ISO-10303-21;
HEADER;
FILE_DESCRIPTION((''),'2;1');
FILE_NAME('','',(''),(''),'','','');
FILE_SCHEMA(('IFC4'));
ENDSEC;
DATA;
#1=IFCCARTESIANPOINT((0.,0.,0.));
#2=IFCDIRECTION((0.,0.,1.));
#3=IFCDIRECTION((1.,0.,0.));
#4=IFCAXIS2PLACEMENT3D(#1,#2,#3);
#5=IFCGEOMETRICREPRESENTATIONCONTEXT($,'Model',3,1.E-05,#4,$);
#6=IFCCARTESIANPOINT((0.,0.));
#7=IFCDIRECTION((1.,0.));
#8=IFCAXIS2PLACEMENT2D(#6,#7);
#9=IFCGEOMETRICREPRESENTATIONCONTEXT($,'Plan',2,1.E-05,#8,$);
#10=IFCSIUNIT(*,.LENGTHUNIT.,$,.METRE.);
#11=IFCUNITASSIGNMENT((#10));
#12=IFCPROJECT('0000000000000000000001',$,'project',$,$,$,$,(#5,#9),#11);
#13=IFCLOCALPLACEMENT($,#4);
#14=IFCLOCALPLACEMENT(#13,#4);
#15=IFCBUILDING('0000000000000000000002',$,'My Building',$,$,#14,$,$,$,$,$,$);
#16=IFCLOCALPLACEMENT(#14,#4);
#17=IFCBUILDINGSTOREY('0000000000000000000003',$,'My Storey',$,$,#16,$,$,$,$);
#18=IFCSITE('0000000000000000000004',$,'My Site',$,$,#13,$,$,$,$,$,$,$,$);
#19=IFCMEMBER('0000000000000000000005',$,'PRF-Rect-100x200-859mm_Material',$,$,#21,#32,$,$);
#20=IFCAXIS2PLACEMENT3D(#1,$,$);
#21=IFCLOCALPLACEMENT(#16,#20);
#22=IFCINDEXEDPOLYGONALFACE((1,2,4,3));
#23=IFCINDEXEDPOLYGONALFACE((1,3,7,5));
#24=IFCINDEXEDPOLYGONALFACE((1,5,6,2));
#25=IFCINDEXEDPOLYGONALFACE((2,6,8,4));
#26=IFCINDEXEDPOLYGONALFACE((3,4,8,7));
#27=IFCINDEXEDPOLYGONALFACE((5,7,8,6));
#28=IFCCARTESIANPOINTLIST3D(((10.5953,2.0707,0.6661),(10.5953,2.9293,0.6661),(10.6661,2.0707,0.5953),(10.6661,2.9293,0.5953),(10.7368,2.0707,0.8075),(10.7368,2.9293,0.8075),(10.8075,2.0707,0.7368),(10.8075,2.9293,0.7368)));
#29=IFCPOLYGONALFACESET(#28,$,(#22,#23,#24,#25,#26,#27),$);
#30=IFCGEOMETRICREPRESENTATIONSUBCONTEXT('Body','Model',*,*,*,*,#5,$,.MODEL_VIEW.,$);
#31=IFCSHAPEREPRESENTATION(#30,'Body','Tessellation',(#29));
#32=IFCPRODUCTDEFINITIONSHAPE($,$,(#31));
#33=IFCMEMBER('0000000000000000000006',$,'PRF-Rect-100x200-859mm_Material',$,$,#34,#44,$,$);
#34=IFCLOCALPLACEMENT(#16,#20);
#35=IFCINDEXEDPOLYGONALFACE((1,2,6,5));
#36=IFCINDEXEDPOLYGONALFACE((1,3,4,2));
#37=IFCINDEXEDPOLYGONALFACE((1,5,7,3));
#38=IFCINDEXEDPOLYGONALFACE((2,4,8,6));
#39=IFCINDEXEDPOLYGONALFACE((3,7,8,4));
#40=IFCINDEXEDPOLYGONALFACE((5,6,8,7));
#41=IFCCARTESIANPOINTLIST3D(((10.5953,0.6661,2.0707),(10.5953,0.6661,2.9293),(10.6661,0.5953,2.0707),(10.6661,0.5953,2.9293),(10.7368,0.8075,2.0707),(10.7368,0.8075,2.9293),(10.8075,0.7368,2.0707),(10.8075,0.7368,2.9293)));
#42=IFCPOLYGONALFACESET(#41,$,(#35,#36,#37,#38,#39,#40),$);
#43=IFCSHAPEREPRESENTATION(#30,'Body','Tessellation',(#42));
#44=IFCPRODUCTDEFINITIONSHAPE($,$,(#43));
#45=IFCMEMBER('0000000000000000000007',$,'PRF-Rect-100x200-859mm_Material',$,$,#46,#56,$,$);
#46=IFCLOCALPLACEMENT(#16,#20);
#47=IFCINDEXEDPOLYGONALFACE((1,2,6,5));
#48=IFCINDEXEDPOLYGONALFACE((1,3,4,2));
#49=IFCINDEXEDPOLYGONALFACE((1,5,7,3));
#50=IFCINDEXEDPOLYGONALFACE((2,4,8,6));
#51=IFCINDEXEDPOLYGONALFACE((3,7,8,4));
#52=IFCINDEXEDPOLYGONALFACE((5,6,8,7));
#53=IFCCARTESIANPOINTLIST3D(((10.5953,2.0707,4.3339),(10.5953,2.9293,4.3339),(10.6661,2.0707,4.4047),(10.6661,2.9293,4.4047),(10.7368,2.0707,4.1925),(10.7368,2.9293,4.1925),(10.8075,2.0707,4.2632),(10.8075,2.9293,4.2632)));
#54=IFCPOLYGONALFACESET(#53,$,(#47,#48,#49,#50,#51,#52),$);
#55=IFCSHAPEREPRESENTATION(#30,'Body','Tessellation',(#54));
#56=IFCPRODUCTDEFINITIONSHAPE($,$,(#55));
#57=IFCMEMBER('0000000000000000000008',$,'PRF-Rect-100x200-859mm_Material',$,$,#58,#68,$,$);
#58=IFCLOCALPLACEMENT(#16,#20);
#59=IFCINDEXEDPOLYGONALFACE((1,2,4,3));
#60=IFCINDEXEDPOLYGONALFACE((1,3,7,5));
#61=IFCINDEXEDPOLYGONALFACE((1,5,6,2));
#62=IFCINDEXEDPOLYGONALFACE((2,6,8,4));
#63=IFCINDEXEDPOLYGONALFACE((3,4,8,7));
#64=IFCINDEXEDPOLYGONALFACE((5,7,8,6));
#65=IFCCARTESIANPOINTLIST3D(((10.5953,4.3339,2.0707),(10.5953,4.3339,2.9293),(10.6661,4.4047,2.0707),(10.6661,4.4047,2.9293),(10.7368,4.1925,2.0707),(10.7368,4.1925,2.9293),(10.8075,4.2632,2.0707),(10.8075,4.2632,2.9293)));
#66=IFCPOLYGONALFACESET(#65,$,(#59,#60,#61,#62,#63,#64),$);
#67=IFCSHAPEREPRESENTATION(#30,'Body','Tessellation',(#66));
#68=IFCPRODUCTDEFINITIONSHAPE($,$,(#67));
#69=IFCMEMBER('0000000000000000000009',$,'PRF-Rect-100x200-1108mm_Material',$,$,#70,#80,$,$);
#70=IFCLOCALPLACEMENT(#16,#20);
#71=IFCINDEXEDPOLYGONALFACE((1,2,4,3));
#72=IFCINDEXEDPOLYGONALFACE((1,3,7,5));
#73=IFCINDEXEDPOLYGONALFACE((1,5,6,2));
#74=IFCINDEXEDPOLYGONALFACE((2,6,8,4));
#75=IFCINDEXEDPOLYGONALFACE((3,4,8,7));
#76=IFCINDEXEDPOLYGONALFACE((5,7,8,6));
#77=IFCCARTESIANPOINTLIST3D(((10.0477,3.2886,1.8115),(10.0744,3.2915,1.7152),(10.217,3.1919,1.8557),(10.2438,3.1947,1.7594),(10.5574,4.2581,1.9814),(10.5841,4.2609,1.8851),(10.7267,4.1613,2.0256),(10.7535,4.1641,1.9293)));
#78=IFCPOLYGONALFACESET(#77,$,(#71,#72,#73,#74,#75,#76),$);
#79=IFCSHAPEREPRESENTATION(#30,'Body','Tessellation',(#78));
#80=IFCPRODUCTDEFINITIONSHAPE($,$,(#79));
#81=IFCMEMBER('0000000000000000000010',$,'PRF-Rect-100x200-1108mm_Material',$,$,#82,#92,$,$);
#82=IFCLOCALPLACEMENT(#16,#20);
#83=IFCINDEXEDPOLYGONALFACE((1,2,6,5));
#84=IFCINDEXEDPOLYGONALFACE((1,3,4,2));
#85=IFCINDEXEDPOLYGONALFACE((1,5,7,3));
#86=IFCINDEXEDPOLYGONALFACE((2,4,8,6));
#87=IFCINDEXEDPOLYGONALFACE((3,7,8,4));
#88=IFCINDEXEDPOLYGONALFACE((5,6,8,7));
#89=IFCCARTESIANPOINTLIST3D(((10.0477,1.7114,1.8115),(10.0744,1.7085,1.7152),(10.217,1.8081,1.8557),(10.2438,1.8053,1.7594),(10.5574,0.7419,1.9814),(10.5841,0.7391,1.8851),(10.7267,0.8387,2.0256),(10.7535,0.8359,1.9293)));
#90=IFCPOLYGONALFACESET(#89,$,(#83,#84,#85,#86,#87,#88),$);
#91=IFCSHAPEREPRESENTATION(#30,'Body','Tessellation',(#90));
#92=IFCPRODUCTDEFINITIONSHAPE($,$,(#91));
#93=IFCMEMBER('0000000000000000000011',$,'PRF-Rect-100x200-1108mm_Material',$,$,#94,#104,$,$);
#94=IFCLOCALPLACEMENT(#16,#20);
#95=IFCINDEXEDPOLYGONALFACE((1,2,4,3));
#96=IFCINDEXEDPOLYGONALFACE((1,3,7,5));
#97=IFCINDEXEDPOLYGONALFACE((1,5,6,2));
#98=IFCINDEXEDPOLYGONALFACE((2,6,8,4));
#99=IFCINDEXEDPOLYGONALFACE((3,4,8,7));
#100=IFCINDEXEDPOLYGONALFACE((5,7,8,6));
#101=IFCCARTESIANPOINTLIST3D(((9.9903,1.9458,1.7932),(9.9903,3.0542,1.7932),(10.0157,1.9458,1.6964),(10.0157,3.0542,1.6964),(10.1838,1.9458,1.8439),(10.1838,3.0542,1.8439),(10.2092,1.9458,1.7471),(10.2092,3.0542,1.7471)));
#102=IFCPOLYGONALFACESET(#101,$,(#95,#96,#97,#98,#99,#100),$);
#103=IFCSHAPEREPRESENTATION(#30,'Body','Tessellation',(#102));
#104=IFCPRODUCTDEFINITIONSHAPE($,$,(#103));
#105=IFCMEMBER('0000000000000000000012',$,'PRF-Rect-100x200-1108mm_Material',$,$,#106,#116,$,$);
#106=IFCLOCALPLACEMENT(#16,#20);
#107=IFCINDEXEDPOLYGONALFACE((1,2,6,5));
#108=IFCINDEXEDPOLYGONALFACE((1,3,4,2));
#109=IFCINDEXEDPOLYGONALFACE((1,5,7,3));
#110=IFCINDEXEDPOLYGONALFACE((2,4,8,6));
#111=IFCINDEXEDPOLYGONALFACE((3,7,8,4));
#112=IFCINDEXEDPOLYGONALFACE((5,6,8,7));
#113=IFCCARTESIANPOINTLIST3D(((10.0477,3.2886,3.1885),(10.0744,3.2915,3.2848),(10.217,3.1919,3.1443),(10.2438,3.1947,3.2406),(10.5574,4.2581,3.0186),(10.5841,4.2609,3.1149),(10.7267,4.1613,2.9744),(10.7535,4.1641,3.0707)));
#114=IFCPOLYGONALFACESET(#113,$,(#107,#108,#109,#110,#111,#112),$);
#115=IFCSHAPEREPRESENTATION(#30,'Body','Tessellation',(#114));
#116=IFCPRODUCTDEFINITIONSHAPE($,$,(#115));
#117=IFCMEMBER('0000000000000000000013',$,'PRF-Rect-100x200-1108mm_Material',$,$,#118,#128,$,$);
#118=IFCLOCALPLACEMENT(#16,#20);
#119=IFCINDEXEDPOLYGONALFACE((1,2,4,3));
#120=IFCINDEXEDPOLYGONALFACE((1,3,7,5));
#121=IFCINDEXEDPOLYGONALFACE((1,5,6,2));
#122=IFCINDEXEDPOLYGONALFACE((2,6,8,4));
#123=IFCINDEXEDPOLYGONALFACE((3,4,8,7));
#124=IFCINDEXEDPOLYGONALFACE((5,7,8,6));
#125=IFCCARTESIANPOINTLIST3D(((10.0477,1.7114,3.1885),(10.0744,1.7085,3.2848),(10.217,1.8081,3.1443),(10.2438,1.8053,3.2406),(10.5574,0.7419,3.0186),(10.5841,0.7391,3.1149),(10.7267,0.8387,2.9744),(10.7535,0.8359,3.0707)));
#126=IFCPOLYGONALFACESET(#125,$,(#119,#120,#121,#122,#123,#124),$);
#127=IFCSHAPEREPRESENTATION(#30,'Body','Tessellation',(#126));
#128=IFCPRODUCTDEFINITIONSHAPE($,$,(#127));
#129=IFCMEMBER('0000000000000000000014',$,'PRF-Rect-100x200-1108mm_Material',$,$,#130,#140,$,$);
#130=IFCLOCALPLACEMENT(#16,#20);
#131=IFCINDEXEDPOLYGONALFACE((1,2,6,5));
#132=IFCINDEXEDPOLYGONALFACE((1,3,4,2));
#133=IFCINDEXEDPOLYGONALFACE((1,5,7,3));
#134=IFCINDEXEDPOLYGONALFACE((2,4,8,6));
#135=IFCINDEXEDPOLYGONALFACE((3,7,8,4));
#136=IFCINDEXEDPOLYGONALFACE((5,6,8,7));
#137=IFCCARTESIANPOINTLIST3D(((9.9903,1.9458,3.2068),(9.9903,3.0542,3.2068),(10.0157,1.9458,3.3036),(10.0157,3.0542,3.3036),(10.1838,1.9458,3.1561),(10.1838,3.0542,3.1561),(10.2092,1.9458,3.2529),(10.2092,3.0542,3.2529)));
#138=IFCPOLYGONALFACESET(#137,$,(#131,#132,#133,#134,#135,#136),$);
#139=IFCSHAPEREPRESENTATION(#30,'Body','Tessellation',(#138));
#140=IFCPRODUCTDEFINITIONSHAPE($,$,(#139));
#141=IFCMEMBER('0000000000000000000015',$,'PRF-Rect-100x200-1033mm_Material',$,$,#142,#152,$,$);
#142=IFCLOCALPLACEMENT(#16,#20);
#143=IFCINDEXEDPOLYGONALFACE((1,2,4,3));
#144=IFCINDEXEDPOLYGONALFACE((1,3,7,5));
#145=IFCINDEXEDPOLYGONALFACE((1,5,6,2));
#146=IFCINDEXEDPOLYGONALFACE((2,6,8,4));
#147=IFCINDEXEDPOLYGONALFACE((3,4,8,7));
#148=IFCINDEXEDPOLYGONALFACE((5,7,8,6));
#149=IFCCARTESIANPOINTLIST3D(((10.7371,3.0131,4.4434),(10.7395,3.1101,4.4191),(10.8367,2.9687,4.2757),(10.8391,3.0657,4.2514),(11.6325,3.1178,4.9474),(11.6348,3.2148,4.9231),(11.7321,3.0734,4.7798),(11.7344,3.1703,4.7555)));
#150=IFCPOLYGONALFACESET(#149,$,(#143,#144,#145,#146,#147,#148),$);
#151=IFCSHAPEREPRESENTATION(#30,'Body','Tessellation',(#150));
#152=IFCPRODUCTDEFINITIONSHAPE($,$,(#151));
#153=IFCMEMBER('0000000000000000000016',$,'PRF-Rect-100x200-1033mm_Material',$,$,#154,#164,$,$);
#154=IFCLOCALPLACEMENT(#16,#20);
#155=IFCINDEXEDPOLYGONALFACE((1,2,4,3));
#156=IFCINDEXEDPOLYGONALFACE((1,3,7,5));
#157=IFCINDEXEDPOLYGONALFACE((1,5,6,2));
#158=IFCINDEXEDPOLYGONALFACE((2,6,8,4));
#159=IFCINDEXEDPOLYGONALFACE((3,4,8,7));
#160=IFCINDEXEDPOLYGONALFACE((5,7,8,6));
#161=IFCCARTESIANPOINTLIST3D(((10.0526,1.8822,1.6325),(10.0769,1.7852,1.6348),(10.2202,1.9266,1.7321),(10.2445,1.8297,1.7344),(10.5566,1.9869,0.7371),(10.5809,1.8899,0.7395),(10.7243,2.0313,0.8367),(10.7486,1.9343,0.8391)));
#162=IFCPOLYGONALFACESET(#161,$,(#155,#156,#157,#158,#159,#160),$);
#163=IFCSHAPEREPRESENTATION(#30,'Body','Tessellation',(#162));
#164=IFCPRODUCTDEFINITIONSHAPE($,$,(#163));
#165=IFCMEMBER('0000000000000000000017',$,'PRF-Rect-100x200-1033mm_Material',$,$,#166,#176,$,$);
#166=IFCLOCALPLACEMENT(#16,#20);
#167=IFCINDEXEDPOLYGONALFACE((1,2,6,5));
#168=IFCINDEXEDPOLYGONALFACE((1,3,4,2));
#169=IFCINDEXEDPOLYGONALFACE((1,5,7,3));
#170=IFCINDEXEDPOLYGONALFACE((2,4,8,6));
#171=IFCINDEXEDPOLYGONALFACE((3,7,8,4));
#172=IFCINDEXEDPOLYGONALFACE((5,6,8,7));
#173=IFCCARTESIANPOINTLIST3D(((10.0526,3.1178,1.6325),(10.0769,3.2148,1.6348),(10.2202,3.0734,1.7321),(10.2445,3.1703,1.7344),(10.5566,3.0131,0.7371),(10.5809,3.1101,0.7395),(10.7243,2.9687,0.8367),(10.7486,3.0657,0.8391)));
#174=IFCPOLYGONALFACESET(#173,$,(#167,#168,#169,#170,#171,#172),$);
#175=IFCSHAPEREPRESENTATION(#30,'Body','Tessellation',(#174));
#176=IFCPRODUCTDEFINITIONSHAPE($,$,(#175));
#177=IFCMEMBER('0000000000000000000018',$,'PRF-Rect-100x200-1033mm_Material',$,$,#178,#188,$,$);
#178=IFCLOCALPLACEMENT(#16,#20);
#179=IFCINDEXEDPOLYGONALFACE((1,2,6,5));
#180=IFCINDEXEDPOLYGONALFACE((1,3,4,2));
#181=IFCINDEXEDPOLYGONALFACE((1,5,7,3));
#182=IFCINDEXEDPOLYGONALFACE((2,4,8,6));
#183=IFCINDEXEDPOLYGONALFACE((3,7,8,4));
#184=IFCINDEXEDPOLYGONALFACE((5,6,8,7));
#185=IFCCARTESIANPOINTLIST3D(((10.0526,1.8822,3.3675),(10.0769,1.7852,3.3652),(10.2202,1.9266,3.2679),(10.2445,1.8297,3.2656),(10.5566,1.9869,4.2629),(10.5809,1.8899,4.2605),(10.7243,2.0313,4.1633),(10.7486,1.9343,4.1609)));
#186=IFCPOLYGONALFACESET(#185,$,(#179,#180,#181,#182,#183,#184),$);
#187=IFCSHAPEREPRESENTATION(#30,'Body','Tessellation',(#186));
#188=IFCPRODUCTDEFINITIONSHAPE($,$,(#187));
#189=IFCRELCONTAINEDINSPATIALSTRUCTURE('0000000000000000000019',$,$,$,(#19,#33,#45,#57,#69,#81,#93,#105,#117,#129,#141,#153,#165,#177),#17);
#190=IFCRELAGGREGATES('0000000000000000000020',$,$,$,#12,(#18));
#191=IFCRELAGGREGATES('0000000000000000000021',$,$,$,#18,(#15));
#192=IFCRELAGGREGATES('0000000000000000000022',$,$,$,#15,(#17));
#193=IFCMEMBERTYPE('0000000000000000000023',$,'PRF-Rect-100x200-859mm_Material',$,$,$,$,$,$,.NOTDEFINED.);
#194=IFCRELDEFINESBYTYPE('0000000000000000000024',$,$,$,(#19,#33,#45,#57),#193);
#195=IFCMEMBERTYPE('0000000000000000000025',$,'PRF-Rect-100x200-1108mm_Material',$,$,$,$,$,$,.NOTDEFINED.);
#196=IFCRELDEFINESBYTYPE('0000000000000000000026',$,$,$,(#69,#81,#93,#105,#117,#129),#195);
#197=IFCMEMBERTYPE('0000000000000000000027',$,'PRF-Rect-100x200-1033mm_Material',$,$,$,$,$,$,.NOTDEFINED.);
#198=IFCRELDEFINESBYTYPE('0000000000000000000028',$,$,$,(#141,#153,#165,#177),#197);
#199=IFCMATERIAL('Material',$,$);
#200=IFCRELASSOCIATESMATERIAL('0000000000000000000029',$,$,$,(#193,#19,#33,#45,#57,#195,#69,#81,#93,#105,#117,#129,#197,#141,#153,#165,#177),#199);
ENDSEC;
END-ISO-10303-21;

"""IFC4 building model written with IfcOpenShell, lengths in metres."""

from ifc_helpers import new_model, si_unit, frame, origin, origin_with_axes, origin_2d_with_axis, place, context, subcontext, project, spatial, rectangle, extrude, material, material_profile, profile_set, profile_usage, type_object, element, save


model = new_model("IFC4")

# Units and contexts
model_context = context("Model", 3, precision=1e-05, world=origin_with_axes())
plan_context = context("Plan", 2, precision=1e-05, world=origin_2d_with_axis())
body_context = subcontext(model_context, "Body", "Model", "MODEL_VIEW")
ifc_project = project(units=[si_unit("LENGTHUNIT", "METRE")], contexts=[model_context, plan_context])

# Site, building, storey
site_placement = place(None, origin_with_axes())
site = spatial("IfcSite", under=ifc_project, at=site_placement, Name="My Site")
building_placement = place(site_placement, origin_with_axes())
building = spatial("IfcBuilding", under=site, at=building_placement, Name="My Building")
storey_placement = place(building_placement, origin_with_axes())
storey = spatial("IfcBuildingStorey", under=building, at=storey_placement, Name="My Storey")

# Members
ifc_material_1 = material(Name="Material")
ifc_material_profile_1 = material_profile(ifc_material_1, rectangle(XDim=0.1, YDim=0.2))
ifc_profile_set_1 = profile_set([ifc_material_profile_1], Name="PRF-Rect-100x200-859mm_Material")
member_type_1 = type_object("IfcMemberType", Name="PRF-Rect-100x200-859mm_Material", PredefinedType="NOTDEFINED", material=ifc_profile_set_1)
ifc_profile_usage_1 = profile_usage(ifc_profile_set_1, cardinal=5)
member_1_placement = place(storey_placement, frame((10.7014, 2.9293, 0.7014), z_axis=(0.0, -1.0, 0.0), x_axis=(-0.707107, 0.0, 0.707107)))
element("IfcMember", 1, at=member_1_placement, inside=storey, type_object=member_type_1, material=ifc_profile_usage_1, Name="PRF-Rect-100x200-859mm_Material", context=body_context, shape_type="SweptSolid", body=[
    extrude(rectangle(XDim=0.1, YDim=0.2), origin(), (0.0, 0.0, 1.0), 0.8586),
])
ifc_profile_usage_2 = profile_usage(ifc_profile_set_1, cardinal=5)
member_2_placement = place(storey_placement, frame((10.7014, 0.7014, 2.0707), z_axis=(0.0, 0.0, 1.0), x_axis=(-0.707107, 0.707107, 0.0)))
element("IfcMember", 2, at=member_2_placement, inside=storey, type_object=member_type_1, material=ifc_profile_usage_2, Name="PRF-Rect-100x200-859mm_Material", context=body_context, shape_type="SweptSolid", body=[
    extrude(rectangle(XDim=0.1, YDim=0.2), origin(), (0.0, 0.0, 1.0), 0.8586),
])
ifc_profile_usage_3 = profile_usage(ifc_profile_set_1, cardinal=5)
member_3_placement = place(storey_placement, frame((10.7014, 2.0707, 4.2986), z_axis=(0.0, 1.0, 0.0), x_axis=(-0.707107, 0.0, -0.707107)))
element("IfcMember", 3, at=member_3_placement, inside=storey, type_object=member_type_1, material=ifc_profile_usage_3, Name="PRF-Rect-100x200-859mm_Material", context=body_context, shape_type="SweptSolid", body=[
    extrude(rectangle(XDim=0.1, YDim=0.2), origin(), (0.0, 0.0, 1.0), 0.8586),
])
ifc_profile_usage_4 = profile_usage(ifc_profile_set_1, cardinal=5)
member_4_placement = place(storey_placement, frame((10.7014, 4.2986, 2.9293), z_axis=(0.0, 0.0, -1.0), x_axis=(-0.707107, -0.707107, 0.0)))
element("IfcMember", 4, at=member_4_placement, inside=storey, type_object=member_type_1, material=ifc_profile_usage_4, Name="PRF-Rect-100x200-859mm_Material", context=body_context, shape_type="SweptSolid", body=[
    extrude(rectangle(XDim=0.1, YDim=0.2), origin(), (0.0, 0.0, 1.0), 0.8586),
])
ifc_material_profile_2 = material_profile(ifc_material_1, rectangle(XDim=0.1, YDim=0.2))
ifc_profile_set_2 = profile_set([ifc_material_profile_2], Name="PRF-Rect-100x200-1108mm_Material")
ifc_profile_usage_5 = profile_usage(ifc_profile_set_2, cardinal=5)
member_type_2 = type_object("IfcMemberType", Name="PRF-Rect-100x200-1108mm_Material", PredefinedType="NOTDEFINED", material=ifc_profile_set_2)
member_5_placement = place(storey_placement, frame((10.1457, 3.2417, 1.7855), z_axis=(0.459849, 0.874668, 0.153283), x_axis=(0.2675, 0.028153, -0.963147)))
element("IfcMember", 5, at=member_5_placement, inside=storey, type_object=member_type_2, material=ifc_profile_usage_5, Name="PRF-Rect-100x200-1108mm_Material", context=body_context, shape_type="SweptSolid", body=[
    extrude(rectangle(XDim=0.1, YDim=0.2), origin(), (0.0, 0.0, 1.0), 1.1084),
])
ifc_profile_usage_6 = profile_usage(ifc_profile_set_2, cardinal=5)
member_6_placement = place(storey_placement, frame((10.6554, 0.7889, 1.9554), z_axis=(-0.459849, 0.874668, -0.153283), x_axis=(0.2675, -0.028153, -0.963147)))
element("IfcMember", 6, at=member_6_placement, inside=storey, type_object=member_type_2, material=ifc_profile_usage_6, Name="PRF-Rect-100x200-1108mm_Material", context=body_context, shape_type="SweptSolid", body=[
    extrude(rectangle(XDim=0.1, YDim=0.2), origin(), (0.0, 0.0, 1.0), 1.1084),
])
ifc_profile_usage_7 = profile_usage(ifc_profile_set_2, cardinal=5)
member_7_placement = place(storey_placement, frame((10.0998, 1.9458, 1.7702), z_axis=(0.0, 1.0, 0.0), x_axis=(0.253569, 0.0, -0.967317)))
element("IfcMember", 7, at=member_7_placement, inside=storey, type_object=member_type_2, material=ifc_profile_usage_7, Name="PRF-Rect-100x200-1108mm_Material", context=body_context, shape_type="SweptSolid", body=[
    extrude(rectangle(XDim=0.1, YDim=0.2), origin(), (0.0, 0.0, 1.0), 1.1084),
])
ifc_profile_usage_8 = profile_usage(ifc_profile_set_2, cardinal=5)
member_8_placement = place(storey_placement, frame((10.1457, 3.2417, 3.2145), z_axis=(0.459849, 0.874667, -0.153283), x_axis=(-0.2675, -0.028153, -0.963147)))
element("IfcMember", 8, at=member_8_placement, inside=storey, type_object=member_type_2, material=ifc_profile_usage_8, Name="PRF-Rect-100x200-1108mm_Material", context=body_context, shape_type="SweptSolid", body=[
    extrude(rectangle(XDim=0.1, YDim=0.2), origin(), (0.0, 0.0, 1.0), 1.1084),
])
ifc_profile_usage_9 = profile_usage(ifc_profile_set_2, cardinal=5)
member_9_placement = place(storey_placement, frame((10.6554, 0.7889, 3.0446), z_axis=(-0.459849, 0.874668, 0.153283), x_axis=(-0.2675, 0.028153, -0.963147)))
element("IfcMember", 9, at=member_9_placement, inside=storey, type_object=member_type_2, material=ifc_profile_usage_9, Name="PRF-Rect-100x200-1108mm_Material", context=body_context, shape_type="SweptSolid", body=[
    extrude(rectangle(XDim=0.1, YDim=0.2), origin(), (0.0, 0.0, 1.0), 1.1084),
])
ifc_profile_usage_10 = profile_usage(ifc_profile_set_2, cardinal=5)
member_10_placement = place(storey_placement, frame((10.0998, 1.9458, 3.2298), z_axis=(0.0, 1.0, 0.0), x_axis=(-0.253569, 0.0, -0.967317)))
element("IfcMember", 10, at=member_10_placement, inside=storey, type_object=member_type_2, material=ifc_profile_usage_10, Name="PRF-Rect-100x200-1108mm_Material", context=body_context, shape_type="SweptSolid", body=[
    extrude(rectangle(XDim=0.1, YDim=0.2), origin(), (0.0, 0.0, 1.0), 1.1084),
])
ifc_material_profile_3 = material_profile(ifc_material_1, rectangle(XDim=0.1, YDim=0.2))
ifc_profile_set_3 = profile_set([ifc_material_profile_3], Name="PRF-Rect-100x200-1033mm_Material")
ifc_profile_usage_11 = profile_usage(ifc_profile_set_3, cardinal=5)
member_type_3 = type_object("IfcMemberType", Name="PRF-Rect-100x200-1033mm_Material", PredefinedType="NOTDEFINED", material=ifc_profile_set_3)
member_11_placement = place(storey_placement, frame((10.7881, 3.0394, 4.3474), z_axis=(0.866922, 0.101314, 0.488039), x_axis=(0.023455, 0.969748, -0.242978)))
element("IfcMember", 11, at=member_11_placement, inside=storey, type_object=member_type_3, material=ifc_profile_usage_11, Name="PRF-Rect-100x200-1033mm_Material", context=body_context, shape_type="SweptSolid", body=[
    extrude(rectangle(XDim=0.1, YDim=0.2), origin(), (0.0, 0.0, 1.0), 1.0328),
])
ifc_profile_usage_12 = profile_usage(ifc_profile_set_3, cardinal=5)
member_12_placement = place(storey_placement, frame((10.1486, 1.8559, 1.6835), z_axis=(0.488039, 0.101314, -0.866922), x_axis=(0.242978, -0.969748, 0.023455)))
element("IfcMember", 12, at=member_12_placement, inside=storey, type_object=member_type_3, material=ifc_profile_usage_12, Name="PRF-Rect-100x200-1033mm_Material", context=body_context, shape_type="SweptSolid", body=[
    extrude(rectangle(XDim=0.1, YDim=0.2), origin(), (0.0, 0.0, 1.0), 1.0328),
])
ifc_profile_usage_13 = profile_usage(ifc_profile_set_3, cardinal=5)
member_13_placement = place(storey_placement, frame((10.1486, 3.1441, 1.6835), z_axis=(0.488039, -0.101315, -0.866922), x_axis=(-0.242978, -0.969748, -0.023454)))
element("IfcMember", 13, at=member_13_placement, inside=storey, type_object=member_type_3, material=ifc_profile_usage_13, Name="PRF-Rect-100x200-1033mm_Material", context=body_context, shape_type="SweptSolid", body=[
    extrude(rectangle(XDim=0.1, YDim=0.2), origin(), (0.0, 0.0, 1.0), 1.0328),
])
ifc_profile_usage_14 = profile_usage(ifc_profile_set_3, cardinal=5)
member_14_placement = place(storey_placement, frame((10.6526, 1.9606, 4.2119), z_axis=(-0.488039, -0.101314, -0.866922), x_axis=(0.242978, -0.969748, -0.023454)))
element("IfcMember", 14, at=member_14_placement, inside=storey, type_object=member_type_3, material=ifc_profile_usage_14, Name="PRF-Rect-100x200-1033mm_Material", context=body_context, shape_type="SweptSolid", body=[
    extrude(rectangle(XDim=0.1, YDim=0.2), origin(), (0.0, 0.0, 1.0), 1.0328),
])

save(model, "model.ifc")
